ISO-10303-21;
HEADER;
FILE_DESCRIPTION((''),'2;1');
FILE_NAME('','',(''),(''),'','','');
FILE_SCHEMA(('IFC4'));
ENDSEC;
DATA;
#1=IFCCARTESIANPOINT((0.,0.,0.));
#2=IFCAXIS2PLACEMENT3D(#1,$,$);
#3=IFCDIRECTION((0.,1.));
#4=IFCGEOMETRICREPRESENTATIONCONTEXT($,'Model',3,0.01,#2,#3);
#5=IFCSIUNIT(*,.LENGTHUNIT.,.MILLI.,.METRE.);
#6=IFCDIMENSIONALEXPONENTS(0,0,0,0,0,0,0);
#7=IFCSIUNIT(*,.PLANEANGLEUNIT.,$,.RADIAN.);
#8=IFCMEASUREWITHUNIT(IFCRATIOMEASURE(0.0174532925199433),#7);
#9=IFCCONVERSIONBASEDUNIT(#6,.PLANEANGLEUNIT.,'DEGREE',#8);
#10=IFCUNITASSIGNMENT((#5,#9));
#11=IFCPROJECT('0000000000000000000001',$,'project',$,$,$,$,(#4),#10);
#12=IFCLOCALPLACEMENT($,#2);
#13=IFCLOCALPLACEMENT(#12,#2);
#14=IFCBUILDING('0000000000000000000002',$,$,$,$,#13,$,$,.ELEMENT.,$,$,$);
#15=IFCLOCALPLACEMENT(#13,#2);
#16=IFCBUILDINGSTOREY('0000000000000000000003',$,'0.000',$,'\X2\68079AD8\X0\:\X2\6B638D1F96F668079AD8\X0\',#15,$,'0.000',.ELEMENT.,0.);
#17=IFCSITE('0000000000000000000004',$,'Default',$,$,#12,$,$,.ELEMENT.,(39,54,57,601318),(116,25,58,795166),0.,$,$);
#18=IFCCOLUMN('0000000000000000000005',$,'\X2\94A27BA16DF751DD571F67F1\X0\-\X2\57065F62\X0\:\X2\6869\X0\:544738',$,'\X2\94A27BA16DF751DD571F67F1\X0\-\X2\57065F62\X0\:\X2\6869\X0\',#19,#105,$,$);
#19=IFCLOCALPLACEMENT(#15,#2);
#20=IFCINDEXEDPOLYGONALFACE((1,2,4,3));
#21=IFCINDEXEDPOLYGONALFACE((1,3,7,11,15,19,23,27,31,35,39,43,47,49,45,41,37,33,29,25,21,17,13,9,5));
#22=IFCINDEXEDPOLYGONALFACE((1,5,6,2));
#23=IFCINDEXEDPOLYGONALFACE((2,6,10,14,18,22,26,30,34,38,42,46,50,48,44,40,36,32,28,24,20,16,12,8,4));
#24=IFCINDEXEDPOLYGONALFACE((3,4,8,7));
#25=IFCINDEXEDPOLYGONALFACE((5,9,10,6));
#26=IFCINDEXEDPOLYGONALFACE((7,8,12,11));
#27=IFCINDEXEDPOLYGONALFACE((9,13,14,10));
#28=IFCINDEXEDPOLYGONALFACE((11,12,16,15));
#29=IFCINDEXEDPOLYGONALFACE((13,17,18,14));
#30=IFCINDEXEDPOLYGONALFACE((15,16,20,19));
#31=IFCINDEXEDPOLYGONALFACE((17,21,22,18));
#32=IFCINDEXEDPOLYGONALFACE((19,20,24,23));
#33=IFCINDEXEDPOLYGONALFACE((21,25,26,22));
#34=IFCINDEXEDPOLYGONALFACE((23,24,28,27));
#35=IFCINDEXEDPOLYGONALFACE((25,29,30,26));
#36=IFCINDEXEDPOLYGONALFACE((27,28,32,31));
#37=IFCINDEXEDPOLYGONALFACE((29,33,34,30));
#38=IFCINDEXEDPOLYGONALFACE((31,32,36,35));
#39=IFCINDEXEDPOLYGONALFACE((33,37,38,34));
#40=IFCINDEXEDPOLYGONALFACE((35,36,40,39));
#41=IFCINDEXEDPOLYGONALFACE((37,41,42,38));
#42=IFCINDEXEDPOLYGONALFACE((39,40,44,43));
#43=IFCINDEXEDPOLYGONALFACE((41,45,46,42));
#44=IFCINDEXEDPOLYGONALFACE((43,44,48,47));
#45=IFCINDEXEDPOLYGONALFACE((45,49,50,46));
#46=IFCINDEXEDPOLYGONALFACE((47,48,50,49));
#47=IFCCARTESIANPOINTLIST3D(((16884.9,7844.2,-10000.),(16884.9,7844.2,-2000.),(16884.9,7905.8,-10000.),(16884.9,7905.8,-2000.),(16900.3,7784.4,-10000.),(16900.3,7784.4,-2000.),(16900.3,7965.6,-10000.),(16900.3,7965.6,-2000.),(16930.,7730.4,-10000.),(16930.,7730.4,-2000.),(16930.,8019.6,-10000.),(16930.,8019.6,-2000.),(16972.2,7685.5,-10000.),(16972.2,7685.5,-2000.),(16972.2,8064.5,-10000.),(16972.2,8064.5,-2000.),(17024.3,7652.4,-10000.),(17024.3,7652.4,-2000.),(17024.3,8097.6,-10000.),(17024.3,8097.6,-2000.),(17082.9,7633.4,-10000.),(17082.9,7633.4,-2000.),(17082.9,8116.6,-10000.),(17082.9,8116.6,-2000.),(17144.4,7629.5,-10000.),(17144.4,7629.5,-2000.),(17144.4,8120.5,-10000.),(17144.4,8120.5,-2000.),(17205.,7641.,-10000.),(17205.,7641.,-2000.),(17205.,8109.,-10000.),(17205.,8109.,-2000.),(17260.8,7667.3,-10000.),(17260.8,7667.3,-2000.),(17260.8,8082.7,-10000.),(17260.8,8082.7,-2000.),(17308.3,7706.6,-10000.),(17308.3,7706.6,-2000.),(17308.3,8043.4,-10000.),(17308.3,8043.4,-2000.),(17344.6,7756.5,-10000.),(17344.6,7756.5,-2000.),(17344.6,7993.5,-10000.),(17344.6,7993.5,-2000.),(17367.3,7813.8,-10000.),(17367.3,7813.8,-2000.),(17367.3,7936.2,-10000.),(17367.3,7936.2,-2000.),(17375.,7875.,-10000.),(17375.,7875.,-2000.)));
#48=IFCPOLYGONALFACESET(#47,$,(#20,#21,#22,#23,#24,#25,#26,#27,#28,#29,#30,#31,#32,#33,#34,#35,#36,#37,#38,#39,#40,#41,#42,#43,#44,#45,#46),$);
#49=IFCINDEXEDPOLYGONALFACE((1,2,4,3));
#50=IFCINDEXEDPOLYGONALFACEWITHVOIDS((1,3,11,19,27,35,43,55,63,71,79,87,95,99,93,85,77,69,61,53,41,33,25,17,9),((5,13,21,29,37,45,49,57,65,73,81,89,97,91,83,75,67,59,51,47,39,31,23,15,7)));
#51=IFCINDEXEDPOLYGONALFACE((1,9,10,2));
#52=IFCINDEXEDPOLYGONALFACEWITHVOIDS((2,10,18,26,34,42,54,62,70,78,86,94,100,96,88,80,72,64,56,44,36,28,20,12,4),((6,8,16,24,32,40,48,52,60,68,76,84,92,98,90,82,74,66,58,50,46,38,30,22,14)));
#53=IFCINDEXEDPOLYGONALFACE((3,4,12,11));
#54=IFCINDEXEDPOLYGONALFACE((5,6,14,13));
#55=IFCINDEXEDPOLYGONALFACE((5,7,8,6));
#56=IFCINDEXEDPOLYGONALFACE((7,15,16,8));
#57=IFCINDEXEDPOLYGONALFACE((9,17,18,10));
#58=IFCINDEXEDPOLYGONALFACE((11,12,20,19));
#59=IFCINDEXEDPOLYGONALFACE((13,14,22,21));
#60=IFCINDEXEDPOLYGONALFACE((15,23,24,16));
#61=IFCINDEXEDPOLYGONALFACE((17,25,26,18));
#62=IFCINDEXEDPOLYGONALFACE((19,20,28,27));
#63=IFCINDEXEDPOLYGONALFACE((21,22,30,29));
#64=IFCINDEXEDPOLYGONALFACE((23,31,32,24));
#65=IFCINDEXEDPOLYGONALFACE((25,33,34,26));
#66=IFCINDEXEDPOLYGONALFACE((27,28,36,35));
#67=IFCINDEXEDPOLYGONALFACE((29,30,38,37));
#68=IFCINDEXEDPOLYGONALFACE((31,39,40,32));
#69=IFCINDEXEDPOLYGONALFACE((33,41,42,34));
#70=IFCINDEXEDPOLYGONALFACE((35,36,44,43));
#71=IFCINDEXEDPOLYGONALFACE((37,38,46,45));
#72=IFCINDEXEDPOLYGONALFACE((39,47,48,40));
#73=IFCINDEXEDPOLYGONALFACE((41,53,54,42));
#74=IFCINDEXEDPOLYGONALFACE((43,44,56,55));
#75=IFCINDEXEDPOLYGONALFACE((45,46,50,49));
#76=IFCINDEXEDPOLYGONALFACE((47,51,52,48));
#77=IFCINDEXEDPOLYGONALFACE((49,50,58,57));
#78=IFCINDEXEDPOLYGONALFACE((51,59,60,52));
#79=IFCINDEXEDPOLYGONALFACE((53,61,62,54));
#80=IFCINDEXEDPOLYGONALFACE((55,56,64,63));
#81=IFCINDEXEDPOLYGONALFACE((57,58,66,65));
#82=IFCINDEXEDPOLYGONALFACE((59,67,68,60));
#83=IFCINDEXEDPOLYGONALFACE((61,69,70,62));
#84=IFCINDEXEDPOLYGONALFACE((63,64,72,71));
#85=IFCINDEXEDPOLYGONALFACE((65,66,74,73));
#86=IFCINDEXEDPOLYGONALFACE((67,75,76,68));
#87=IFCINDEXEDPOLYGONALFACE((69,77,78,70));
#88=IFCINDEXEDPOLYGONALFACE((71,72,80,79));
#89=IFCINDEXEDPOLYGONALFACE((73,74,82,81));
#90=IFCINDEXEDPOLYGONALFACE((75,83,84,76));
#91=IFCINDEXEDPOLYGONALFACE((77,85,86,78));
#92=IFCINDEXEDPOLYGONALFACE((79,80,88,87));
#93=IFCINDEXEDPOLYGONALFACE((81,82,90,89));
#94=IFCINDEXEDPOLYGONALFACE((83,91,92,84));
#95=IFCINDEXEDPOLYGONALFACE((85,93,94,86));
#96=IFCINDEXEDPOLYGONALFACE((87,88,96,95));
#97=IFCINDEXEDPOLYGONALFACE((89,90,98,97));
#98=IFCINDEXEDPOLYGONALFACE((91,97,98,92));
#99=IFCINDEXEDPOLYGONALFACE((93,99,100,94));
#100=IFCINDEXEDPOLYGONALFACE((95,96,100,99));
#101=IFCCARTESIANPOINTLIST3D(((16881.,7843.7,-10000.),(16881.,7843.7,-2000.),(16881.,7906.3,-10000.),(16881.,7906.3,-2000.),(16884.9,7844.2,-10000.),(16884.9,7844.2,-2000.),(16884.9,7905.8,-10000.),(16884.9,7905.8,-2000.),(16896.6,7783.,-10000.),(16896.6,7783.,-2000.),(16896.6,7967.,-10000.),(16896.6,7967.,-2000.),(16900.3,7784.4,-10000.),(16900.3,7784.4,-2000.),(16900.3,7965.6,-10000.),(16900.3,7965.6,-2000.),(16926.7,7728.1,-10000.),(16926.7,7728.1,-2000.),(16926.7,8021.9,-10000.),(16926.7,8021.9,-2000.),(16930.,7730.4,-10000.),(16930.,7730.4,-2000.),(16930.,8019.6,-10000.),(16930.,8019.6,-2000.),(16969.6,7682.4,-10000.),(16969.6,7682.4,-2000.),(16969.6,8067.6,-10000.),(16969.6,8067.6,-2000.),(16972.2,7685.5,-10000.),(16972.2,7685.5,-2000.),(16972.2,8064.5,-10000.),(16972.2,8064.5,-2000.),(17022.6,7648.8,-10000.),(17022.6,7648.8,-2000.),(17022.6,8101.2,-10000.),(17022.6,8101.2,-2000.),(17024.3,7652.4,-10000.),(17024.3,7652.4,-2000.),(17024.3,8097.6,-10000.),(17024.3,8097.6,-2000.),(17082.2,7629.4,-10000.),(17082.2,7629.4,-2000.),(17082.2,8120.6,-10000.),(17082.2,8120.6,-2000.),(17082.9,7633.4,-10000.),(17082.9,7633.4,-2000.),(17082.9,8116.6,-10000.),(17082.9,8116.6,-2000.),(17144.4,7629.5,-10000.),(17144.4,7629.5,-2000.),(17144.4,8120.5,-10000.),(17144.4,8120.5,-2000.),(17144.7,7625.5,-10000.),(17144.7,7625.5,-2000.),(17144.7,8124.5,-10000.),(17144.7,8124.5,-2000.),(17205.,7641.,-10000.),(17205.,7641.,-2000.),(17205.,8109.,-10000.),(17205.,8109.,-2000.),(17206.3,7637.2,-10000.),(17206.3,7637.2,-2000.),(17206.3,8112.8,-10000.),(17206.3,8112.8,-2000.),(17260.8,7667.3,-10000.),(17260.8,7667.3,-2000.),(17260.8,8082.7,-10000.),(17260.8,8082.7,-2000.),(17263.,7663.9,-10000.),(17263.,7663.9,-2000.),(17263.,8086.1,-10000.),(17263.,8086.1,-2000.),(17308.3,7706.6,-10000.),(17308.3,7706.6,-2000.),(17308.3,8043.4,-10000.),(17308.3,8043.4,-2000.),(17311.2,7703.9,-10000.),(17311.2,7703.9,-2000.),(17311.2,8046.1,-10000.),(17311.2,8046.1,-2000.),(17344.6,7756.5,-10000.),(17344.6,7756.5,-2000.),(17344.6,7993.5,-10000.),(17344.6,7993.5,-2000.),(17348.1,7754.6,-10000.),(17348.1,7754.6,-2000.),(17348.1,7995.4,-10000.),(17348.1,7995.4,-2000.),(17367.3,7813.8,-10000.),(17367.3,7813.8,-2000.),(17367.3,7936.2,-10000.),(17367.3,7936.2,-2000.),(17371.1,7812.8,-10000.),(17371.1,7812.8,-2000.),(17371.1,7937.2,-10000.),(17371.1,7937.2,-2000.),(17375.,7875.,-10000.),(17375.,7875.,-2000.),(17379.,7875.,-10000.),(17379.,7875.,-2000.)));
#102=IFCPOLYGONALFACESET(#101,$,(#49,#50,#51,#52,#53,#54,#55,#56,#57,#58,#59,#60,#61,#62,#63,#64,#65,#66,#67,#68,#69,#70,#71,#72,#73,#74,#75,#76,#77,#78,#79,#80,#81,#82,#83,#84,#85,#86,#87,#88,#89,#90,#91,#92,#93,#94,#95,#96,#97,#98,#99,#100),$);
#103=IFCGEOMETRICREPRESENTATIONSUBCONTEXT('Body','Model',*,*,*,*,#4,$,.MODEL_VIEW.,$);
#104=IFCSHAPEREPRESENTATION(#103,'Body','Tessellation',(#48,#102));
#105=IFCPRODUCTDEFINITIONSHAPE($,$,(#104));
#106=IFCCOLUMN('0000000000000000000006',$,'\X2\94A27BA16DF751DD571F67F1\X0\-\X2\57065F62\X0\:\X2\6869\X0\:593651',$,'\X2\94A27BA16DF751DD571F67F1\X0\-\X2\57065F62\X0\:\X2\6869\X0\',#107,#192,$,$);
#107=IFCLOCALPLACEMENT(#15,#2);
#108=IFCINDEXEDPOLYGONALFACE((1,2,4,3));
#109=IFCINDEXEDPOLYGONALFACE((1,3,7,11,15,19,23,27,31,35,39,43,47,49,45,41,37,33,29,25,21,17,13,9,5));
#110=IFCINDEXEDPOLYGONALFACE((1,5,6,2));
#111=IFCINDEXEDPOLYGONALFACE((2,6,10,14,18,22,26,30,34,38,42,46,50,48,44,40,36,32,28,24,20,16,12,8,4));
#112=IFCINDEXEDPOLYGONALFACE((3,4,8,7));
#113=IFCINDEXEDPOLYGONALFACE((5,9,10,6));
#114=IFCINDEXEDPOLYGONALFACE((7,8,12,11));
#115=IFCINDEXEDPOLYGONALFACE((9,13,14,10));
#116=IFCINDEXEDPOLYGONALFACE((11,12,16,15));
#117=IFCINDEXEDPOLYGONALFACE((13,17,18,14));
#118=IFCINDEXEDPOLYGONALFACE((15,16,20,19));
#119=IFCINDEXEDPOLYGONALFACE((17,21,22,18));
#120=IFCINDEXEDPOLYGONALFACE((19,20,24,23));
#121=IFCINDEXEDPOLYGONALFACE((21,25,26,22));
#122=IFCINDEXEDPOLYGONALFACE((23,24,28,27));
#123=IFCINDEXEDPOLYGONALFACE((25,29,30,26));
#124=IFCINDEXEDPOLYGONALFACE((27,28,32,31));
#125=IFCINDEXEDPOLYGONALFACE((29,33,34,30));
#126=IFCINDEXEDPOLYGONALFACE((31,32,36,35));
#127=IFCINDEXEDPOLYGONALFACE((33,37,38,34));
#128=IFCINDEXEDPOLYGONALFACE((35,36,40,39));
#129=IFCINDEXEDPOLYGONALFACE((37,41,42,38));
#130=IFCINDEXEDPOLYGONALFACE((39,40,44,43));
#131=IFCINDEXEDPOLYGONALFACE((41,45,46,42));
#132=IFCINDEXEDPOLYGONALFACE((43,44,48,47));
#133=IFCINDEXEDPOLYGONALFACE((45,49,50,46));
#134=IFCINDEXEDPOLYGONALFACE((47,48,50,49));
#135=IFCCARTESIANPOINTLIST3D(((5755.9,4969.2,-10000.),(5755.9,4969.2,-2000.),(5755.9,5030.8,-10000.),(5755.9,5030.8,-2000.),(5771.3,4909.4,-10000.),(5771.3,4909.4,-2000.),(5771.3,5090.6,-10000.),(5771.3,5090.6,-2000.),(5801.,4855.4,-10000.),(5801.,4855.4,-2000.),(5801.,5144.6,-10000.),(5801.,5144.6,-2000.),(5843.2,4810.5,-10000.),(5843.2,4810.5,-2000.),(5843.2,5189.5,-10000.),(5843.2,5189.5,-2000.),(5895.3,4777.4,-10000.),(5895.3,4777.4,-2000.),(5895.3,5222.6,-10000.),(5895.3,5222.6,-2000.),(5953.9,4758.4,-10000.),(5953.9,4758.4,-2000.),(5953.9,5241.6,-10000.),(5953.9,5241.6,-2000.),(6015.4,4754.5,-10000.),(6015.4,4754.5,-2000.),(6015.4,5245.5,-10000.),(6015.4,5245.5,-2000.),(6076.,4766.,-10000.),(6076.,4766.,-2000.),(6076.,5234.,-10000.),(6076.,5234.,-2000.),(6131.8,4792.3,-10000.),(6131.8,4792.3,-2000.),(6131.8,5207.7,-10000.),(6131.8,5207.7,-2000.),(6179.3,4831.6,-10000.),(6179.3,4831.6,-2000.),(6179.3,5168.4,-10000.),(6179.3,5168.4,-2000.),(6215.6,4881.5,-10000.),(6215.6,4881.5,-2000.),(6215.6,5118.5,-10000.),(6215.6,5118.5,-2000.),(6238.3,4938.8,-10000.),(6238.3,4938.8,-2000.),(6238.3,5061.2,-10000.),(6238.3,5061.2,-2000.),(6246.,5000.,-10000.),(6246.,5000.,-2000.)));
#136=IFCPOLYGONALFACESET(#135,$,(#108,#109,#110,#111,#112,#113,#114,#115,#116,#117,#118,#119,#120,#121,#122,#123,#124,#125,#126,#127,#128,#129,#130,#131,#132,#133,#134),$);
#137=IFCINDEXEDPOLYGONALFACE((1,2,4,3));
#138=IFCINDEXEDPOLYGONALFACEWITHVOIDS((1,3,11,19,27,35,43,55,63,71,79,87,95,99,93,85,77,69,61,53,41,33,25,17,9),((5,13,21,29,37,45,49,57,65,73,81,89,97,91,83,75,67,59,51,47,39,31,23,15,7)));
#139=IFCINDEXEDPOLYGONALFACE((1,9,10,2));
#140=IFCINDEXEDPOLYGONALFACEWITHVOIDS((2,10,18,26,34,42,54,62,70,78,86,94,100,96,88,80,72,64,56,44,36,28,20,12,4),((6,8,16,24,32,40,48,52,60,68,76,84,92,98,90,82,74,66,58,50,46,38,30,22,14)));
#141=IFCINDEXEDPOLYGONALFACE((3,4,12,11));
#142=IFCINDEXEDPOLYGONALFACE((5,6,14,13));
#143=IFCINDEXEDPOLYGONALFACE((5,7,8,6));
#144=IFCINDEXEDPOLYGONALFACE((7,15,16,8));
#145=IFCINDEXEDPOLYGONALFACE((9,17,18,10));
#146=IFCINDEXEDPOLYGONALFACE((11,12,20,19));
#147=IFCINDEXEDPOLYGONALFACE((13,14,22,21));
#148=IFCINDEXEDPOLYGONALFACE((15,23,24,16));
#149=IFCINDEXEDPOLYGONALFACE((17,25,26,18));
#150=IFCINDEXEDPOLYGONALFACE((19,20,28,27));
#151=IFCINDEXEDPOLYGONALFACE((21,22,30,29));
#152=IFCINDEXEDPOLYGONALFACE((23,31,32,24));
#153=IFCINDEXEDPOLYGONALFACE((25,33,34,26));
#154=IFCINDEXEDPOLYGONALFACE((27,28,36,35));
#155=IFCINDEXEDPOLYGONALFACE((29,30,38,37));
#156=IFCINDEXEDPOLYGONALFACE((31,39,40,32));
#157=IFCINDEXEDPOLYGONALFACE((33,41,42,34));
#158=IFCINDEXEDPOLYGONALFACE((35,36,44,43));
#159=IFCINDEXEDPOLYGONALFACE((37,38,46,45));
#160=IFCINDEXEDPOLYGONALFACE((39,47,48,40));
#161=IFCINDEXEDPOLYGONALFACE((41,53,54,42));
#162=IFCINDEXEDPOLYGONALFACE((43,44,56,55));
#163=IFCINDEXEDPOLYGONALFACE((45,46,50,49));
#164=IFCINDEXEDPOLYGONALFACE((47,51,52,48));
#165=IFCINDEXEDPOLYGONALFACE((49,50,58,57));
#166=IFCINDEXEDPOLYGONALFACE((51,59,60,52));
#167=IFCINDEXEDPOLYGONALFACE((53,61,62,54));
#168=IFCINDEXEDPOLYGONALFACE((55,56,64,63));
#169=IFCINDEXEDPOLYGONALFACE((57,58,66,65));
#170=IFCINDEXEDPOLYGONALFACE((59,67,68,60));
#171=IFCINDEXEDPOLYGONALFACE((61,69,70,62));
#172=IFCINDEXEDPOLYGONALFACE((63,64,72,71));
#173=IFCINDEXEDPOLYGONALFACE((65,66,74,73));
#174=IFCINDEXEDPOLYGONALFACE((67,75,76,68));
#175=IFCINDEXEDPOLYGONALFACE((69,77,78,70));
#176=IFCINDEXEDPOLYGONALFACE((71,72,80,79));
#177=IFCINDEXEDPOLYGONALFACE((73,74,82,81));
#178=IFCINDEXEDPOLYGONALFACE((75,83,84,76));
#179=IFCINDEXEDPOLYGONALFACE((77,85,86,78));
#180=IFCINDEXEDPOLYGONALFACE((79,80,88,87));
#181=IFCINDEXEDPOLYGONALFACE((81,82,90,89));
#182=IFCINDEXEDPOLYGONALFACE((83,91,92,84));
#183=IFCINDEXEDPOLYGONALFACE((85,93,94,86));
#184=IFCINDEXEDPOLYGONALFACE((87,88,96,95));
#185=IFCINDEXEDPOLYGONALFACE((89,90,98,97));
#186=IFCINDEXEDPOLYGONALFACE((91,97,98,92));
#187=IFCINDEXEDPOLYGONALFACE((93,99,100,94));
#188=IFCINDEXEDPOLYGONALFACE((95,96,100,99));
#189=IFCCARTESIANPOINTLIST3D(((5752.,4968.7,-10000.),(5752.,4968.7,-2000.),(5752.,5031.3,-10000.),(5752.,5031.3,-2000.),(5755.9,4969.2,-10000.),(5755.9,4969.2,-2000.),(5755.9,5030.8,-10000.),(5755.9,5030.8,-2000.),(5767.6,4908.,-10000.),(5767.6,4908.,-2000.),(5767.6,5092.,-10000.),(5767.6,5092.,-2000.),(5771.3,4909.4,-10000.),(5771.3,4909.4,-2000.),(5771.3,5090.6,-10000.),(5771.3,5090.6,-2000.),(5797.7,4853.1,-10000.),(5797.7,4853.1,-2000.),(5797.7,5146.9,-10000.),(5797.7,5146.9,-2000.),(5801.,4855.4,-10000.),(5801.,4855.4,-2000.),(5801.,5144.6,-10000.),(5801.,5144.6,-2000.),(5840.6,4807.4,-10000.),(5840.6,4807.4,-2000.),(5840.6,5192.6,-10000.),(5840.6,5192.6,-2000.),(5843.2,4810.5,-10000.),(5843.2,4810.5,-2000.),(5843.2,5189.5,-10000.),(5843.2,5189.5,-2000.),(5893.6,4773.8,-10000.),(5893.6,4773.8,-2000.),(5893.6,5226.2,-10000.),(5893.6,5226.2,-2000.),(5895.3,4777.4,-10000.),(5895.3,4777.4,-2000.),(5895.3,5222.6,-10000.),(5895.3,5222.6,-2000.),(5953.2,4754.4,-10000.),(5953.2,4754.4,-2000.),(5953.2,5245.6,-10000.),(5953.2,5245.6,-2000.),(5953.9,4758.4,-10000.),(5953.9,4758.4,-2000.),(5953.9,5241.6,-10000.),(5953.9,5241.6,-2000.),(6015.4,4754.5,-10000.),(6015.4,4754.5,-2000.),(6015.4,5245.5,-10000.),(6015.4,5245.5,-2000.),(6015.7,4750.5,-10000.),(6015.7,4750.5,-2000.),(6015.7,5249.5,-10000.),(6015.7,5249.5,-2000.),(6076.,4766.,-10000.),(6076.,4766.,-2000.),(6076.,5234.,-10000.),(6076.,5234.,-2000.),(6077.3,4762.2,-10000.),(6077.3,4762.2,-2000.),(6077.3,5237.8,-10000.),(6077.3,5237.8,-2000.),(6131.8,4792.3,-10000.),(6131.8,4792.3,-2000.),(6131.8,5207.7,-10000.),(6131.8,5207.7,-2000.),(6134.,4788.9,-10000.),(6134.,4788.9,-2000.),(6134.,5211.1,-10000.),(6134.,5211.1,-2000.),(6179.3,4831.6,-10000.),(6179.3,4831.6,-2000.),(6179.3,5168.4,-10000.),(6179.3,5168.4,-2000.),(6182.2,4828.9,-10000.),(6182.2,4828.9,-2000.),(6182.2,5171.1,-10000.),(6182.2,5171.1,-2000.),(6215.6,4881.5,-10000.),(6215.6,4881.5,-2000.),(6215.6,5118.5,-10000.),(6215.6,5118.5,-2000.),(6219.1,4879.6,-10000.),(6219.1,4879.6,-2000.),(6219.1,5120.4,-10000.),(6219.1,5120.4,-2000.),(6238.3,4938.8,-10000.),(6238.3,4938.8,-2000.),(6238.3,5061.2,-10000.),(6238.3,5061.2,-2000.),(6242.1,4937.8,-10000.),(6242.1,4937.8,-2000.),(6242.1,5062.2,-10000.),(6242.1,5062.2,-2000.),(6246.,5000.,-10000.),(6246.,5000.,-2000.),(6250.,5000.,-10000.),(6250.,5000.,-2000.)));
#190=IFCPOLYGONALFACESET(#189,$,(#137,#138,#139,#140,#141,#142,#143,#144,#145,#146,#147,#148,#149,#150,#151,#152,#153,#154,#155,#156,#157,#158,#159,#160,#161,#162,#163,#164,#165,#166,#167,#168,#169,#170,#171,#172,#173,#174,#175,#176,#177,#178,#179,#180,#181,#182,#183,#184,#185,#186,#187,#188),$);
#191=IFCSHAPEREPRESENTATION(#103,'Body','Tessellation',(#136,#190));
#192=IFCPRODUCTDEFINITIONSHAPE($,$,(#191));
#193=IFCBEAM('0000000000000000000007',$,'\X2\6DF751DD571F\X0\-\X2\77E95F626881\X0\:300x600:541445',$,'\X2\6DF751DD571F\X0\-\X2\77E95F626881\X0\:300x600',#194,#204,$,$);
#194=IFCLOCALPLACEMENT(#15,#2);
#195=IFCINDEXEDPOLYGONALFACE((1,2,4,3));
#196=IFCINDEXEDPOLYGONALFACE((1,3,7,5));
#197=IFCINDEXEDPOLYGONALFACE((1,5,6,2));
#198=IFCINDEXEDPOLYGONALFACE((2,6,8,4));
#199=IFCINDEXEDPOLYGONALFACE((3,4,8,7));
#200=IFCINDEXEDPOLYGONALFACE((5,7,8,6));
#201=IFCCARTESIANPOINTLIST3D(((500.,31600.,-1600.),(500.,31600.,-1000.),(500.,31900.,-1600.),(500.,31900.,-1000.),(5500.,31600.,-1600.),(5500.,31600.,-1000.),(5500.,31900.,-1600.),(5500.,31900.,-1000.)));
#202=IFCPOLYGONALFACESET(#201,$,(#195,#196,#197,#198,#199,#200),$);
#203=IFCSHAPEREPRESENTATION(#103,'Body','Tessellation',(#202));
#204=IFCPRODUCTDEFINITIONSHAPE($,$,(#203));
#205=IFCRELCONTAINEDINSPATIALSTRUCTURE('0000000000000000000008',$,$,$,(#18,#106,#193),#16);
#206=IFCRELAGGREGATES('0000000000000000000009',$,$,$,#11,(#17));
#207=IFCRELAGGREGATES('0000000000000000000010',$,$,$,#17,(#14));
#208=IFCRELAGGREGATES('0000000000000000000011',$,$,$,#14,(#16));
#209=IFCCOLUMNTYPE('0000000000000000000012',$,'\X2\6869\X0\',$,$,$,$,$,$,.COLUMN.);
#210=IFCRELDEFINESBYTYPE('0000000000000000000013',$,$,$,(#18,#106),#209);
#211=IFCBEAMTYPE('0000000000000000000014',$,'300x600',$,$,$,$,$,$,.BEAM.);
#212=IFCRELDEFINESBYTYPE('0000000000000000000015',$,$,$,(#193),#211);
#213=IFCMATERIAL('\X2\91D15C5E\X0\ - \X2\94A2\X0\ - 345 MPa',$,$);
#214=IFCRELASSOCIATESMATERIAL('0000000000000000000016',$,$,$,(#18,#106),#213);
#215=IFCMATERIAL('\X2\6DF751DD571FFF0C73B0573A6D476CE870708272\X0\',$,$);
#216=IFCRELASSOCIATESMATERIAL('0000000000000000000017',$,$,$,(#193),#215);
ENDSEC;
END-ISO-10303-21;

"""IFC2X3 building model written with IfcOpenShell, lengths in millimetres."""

from ifc_helpers import new_model, entity, si_unit, converted_unit, direction, frame, frame_2d, origin, place, context, subcontext, project, spatial, rectangle, circle, hollow_circle, extrude, source, transform, mapped, material, type_object, type_shapes, element, save


model = new_model("IFC2X3")

# Units and contexts
model_context = context("Model", 3, precision=0.01, world=origin(), true_north=direction((0.0, 1.0)))
body_context = subcontext(model_context, "Body", "Model", "MODEL_VIEW")
ifc_project = project(units=[si_unit("LENGTHUNIT", "METRE", prefix="MILLI"), converted_unit("PLANEANGLEUNIT", "DEGREE", entity("IfcRatioMeasure", 0.0174532925199433), si_unit("PLANEANGLEUNIT", "RADIAN"), dimensions=[0, 0, 0, 0, 0, 0, 0])], contexts=[model_context])

# Site, building, storey
site_placement = place(None, origin())
site = spatial("IfcSite", under=ifc_project, at=site_placement, Name="Default", CompositionType="ELEMENT", RefLatitude=(39, 54, 57, 601318), RefLongitude=(116, 25, 58, 795166), RefElevation=0.0)
building_placement = place(site_placement, origin())
building = spatial("IfcBuilding", under=site, at=building_placement, CompositionType="ELEMENT")
storey_placement = place(building_placement, origin())
storey = spatial("IfcBuildingStorey", under=building, at=storey_placement, Name="0.000", ObjectType="标高:正负零标高", LongName="0.000", CompositionType="ELEMENT", Elevation=0.0)

# Columns
ifc_material_1 = material(Name="金属 - 钢 - 345 MPa")
column_type = type_object("IfcColumnType", Name="桩", PredefinedType="COLUMN")
shared_shape = source(origin(), body_context, "Body", "SweptSolid", [
    extrude(circle(Radius=246.0, at=frame_2d((0.0, 0.0), x_axis=(1.0, 0.0))), frame((0.0, 0.0, -10000.0)), (0.0, 0.0, 1.0), 8000.0),
    extrude(hollow_circle(Radius=250.0, WallThickness=4.0, at=frame_2d((0.0, 0.0), x_axis=(1.0, 0.0))), frame((0.0, 0.0, -10000.0)), (0.0, 0.0, 1.0), 8000.0),
])
type_shapes(column_type, [shared_shape])
for number, where, name in (
    (1, (17129.0, 7875.0, 0.0), "钢管混凝土柱-圆形:桩:544738"),
    (2, (6000.0, 5000.0, 0.0), "钢管混凝土柱-圆形:桩:593651"),
):
    element("IfcColumn", number, at=place(storey_placement, frame(where)), inside=storey, type_object=column_type, material=ifc_material_1, Name=name, ObjectType="钢管混凝土柱-圆形:桩", context=body_context, shape_type="MappedRepresentation", body=[
        mapped(shared_shape, transform((0.0, 0.0, 0.0), scale=1.0)),
    ])

# Beam
ifc_material_2 = material(Name="混凝土，现场浇注灰色")
beam_type_1 = type_object("IfcBeamType", Name="300x600", PredefinedType="BEAM")
beam_1_placement = place(storey_placement, frame((500.0, 31900.0, 0.0)))
element("IfcBeam", 3, at=beam_1_placement, inside=storey, type_object=beam_type_1, material=ifc_material_2, Name="混凝土-矩形梁:300x600:541445", ObjectType="混凝土-矩形梁:300x600", context=body_context, shape_type="SweptSolid", body=[
    extrude(rectangle(XDim=600.0, YDim=300.0, at=frame_2d((0.0, 0.0), x_axis=(1.0, 0.0))), frame((0.0, -150.0, -1300.0), z_axis=(1.0, 0.0, 0.0), x_axis=(0.0, 0.0, -1.0)), (0.0, 0.0, 1.0), 5000.0),
])

save(model, "model.ifc")
